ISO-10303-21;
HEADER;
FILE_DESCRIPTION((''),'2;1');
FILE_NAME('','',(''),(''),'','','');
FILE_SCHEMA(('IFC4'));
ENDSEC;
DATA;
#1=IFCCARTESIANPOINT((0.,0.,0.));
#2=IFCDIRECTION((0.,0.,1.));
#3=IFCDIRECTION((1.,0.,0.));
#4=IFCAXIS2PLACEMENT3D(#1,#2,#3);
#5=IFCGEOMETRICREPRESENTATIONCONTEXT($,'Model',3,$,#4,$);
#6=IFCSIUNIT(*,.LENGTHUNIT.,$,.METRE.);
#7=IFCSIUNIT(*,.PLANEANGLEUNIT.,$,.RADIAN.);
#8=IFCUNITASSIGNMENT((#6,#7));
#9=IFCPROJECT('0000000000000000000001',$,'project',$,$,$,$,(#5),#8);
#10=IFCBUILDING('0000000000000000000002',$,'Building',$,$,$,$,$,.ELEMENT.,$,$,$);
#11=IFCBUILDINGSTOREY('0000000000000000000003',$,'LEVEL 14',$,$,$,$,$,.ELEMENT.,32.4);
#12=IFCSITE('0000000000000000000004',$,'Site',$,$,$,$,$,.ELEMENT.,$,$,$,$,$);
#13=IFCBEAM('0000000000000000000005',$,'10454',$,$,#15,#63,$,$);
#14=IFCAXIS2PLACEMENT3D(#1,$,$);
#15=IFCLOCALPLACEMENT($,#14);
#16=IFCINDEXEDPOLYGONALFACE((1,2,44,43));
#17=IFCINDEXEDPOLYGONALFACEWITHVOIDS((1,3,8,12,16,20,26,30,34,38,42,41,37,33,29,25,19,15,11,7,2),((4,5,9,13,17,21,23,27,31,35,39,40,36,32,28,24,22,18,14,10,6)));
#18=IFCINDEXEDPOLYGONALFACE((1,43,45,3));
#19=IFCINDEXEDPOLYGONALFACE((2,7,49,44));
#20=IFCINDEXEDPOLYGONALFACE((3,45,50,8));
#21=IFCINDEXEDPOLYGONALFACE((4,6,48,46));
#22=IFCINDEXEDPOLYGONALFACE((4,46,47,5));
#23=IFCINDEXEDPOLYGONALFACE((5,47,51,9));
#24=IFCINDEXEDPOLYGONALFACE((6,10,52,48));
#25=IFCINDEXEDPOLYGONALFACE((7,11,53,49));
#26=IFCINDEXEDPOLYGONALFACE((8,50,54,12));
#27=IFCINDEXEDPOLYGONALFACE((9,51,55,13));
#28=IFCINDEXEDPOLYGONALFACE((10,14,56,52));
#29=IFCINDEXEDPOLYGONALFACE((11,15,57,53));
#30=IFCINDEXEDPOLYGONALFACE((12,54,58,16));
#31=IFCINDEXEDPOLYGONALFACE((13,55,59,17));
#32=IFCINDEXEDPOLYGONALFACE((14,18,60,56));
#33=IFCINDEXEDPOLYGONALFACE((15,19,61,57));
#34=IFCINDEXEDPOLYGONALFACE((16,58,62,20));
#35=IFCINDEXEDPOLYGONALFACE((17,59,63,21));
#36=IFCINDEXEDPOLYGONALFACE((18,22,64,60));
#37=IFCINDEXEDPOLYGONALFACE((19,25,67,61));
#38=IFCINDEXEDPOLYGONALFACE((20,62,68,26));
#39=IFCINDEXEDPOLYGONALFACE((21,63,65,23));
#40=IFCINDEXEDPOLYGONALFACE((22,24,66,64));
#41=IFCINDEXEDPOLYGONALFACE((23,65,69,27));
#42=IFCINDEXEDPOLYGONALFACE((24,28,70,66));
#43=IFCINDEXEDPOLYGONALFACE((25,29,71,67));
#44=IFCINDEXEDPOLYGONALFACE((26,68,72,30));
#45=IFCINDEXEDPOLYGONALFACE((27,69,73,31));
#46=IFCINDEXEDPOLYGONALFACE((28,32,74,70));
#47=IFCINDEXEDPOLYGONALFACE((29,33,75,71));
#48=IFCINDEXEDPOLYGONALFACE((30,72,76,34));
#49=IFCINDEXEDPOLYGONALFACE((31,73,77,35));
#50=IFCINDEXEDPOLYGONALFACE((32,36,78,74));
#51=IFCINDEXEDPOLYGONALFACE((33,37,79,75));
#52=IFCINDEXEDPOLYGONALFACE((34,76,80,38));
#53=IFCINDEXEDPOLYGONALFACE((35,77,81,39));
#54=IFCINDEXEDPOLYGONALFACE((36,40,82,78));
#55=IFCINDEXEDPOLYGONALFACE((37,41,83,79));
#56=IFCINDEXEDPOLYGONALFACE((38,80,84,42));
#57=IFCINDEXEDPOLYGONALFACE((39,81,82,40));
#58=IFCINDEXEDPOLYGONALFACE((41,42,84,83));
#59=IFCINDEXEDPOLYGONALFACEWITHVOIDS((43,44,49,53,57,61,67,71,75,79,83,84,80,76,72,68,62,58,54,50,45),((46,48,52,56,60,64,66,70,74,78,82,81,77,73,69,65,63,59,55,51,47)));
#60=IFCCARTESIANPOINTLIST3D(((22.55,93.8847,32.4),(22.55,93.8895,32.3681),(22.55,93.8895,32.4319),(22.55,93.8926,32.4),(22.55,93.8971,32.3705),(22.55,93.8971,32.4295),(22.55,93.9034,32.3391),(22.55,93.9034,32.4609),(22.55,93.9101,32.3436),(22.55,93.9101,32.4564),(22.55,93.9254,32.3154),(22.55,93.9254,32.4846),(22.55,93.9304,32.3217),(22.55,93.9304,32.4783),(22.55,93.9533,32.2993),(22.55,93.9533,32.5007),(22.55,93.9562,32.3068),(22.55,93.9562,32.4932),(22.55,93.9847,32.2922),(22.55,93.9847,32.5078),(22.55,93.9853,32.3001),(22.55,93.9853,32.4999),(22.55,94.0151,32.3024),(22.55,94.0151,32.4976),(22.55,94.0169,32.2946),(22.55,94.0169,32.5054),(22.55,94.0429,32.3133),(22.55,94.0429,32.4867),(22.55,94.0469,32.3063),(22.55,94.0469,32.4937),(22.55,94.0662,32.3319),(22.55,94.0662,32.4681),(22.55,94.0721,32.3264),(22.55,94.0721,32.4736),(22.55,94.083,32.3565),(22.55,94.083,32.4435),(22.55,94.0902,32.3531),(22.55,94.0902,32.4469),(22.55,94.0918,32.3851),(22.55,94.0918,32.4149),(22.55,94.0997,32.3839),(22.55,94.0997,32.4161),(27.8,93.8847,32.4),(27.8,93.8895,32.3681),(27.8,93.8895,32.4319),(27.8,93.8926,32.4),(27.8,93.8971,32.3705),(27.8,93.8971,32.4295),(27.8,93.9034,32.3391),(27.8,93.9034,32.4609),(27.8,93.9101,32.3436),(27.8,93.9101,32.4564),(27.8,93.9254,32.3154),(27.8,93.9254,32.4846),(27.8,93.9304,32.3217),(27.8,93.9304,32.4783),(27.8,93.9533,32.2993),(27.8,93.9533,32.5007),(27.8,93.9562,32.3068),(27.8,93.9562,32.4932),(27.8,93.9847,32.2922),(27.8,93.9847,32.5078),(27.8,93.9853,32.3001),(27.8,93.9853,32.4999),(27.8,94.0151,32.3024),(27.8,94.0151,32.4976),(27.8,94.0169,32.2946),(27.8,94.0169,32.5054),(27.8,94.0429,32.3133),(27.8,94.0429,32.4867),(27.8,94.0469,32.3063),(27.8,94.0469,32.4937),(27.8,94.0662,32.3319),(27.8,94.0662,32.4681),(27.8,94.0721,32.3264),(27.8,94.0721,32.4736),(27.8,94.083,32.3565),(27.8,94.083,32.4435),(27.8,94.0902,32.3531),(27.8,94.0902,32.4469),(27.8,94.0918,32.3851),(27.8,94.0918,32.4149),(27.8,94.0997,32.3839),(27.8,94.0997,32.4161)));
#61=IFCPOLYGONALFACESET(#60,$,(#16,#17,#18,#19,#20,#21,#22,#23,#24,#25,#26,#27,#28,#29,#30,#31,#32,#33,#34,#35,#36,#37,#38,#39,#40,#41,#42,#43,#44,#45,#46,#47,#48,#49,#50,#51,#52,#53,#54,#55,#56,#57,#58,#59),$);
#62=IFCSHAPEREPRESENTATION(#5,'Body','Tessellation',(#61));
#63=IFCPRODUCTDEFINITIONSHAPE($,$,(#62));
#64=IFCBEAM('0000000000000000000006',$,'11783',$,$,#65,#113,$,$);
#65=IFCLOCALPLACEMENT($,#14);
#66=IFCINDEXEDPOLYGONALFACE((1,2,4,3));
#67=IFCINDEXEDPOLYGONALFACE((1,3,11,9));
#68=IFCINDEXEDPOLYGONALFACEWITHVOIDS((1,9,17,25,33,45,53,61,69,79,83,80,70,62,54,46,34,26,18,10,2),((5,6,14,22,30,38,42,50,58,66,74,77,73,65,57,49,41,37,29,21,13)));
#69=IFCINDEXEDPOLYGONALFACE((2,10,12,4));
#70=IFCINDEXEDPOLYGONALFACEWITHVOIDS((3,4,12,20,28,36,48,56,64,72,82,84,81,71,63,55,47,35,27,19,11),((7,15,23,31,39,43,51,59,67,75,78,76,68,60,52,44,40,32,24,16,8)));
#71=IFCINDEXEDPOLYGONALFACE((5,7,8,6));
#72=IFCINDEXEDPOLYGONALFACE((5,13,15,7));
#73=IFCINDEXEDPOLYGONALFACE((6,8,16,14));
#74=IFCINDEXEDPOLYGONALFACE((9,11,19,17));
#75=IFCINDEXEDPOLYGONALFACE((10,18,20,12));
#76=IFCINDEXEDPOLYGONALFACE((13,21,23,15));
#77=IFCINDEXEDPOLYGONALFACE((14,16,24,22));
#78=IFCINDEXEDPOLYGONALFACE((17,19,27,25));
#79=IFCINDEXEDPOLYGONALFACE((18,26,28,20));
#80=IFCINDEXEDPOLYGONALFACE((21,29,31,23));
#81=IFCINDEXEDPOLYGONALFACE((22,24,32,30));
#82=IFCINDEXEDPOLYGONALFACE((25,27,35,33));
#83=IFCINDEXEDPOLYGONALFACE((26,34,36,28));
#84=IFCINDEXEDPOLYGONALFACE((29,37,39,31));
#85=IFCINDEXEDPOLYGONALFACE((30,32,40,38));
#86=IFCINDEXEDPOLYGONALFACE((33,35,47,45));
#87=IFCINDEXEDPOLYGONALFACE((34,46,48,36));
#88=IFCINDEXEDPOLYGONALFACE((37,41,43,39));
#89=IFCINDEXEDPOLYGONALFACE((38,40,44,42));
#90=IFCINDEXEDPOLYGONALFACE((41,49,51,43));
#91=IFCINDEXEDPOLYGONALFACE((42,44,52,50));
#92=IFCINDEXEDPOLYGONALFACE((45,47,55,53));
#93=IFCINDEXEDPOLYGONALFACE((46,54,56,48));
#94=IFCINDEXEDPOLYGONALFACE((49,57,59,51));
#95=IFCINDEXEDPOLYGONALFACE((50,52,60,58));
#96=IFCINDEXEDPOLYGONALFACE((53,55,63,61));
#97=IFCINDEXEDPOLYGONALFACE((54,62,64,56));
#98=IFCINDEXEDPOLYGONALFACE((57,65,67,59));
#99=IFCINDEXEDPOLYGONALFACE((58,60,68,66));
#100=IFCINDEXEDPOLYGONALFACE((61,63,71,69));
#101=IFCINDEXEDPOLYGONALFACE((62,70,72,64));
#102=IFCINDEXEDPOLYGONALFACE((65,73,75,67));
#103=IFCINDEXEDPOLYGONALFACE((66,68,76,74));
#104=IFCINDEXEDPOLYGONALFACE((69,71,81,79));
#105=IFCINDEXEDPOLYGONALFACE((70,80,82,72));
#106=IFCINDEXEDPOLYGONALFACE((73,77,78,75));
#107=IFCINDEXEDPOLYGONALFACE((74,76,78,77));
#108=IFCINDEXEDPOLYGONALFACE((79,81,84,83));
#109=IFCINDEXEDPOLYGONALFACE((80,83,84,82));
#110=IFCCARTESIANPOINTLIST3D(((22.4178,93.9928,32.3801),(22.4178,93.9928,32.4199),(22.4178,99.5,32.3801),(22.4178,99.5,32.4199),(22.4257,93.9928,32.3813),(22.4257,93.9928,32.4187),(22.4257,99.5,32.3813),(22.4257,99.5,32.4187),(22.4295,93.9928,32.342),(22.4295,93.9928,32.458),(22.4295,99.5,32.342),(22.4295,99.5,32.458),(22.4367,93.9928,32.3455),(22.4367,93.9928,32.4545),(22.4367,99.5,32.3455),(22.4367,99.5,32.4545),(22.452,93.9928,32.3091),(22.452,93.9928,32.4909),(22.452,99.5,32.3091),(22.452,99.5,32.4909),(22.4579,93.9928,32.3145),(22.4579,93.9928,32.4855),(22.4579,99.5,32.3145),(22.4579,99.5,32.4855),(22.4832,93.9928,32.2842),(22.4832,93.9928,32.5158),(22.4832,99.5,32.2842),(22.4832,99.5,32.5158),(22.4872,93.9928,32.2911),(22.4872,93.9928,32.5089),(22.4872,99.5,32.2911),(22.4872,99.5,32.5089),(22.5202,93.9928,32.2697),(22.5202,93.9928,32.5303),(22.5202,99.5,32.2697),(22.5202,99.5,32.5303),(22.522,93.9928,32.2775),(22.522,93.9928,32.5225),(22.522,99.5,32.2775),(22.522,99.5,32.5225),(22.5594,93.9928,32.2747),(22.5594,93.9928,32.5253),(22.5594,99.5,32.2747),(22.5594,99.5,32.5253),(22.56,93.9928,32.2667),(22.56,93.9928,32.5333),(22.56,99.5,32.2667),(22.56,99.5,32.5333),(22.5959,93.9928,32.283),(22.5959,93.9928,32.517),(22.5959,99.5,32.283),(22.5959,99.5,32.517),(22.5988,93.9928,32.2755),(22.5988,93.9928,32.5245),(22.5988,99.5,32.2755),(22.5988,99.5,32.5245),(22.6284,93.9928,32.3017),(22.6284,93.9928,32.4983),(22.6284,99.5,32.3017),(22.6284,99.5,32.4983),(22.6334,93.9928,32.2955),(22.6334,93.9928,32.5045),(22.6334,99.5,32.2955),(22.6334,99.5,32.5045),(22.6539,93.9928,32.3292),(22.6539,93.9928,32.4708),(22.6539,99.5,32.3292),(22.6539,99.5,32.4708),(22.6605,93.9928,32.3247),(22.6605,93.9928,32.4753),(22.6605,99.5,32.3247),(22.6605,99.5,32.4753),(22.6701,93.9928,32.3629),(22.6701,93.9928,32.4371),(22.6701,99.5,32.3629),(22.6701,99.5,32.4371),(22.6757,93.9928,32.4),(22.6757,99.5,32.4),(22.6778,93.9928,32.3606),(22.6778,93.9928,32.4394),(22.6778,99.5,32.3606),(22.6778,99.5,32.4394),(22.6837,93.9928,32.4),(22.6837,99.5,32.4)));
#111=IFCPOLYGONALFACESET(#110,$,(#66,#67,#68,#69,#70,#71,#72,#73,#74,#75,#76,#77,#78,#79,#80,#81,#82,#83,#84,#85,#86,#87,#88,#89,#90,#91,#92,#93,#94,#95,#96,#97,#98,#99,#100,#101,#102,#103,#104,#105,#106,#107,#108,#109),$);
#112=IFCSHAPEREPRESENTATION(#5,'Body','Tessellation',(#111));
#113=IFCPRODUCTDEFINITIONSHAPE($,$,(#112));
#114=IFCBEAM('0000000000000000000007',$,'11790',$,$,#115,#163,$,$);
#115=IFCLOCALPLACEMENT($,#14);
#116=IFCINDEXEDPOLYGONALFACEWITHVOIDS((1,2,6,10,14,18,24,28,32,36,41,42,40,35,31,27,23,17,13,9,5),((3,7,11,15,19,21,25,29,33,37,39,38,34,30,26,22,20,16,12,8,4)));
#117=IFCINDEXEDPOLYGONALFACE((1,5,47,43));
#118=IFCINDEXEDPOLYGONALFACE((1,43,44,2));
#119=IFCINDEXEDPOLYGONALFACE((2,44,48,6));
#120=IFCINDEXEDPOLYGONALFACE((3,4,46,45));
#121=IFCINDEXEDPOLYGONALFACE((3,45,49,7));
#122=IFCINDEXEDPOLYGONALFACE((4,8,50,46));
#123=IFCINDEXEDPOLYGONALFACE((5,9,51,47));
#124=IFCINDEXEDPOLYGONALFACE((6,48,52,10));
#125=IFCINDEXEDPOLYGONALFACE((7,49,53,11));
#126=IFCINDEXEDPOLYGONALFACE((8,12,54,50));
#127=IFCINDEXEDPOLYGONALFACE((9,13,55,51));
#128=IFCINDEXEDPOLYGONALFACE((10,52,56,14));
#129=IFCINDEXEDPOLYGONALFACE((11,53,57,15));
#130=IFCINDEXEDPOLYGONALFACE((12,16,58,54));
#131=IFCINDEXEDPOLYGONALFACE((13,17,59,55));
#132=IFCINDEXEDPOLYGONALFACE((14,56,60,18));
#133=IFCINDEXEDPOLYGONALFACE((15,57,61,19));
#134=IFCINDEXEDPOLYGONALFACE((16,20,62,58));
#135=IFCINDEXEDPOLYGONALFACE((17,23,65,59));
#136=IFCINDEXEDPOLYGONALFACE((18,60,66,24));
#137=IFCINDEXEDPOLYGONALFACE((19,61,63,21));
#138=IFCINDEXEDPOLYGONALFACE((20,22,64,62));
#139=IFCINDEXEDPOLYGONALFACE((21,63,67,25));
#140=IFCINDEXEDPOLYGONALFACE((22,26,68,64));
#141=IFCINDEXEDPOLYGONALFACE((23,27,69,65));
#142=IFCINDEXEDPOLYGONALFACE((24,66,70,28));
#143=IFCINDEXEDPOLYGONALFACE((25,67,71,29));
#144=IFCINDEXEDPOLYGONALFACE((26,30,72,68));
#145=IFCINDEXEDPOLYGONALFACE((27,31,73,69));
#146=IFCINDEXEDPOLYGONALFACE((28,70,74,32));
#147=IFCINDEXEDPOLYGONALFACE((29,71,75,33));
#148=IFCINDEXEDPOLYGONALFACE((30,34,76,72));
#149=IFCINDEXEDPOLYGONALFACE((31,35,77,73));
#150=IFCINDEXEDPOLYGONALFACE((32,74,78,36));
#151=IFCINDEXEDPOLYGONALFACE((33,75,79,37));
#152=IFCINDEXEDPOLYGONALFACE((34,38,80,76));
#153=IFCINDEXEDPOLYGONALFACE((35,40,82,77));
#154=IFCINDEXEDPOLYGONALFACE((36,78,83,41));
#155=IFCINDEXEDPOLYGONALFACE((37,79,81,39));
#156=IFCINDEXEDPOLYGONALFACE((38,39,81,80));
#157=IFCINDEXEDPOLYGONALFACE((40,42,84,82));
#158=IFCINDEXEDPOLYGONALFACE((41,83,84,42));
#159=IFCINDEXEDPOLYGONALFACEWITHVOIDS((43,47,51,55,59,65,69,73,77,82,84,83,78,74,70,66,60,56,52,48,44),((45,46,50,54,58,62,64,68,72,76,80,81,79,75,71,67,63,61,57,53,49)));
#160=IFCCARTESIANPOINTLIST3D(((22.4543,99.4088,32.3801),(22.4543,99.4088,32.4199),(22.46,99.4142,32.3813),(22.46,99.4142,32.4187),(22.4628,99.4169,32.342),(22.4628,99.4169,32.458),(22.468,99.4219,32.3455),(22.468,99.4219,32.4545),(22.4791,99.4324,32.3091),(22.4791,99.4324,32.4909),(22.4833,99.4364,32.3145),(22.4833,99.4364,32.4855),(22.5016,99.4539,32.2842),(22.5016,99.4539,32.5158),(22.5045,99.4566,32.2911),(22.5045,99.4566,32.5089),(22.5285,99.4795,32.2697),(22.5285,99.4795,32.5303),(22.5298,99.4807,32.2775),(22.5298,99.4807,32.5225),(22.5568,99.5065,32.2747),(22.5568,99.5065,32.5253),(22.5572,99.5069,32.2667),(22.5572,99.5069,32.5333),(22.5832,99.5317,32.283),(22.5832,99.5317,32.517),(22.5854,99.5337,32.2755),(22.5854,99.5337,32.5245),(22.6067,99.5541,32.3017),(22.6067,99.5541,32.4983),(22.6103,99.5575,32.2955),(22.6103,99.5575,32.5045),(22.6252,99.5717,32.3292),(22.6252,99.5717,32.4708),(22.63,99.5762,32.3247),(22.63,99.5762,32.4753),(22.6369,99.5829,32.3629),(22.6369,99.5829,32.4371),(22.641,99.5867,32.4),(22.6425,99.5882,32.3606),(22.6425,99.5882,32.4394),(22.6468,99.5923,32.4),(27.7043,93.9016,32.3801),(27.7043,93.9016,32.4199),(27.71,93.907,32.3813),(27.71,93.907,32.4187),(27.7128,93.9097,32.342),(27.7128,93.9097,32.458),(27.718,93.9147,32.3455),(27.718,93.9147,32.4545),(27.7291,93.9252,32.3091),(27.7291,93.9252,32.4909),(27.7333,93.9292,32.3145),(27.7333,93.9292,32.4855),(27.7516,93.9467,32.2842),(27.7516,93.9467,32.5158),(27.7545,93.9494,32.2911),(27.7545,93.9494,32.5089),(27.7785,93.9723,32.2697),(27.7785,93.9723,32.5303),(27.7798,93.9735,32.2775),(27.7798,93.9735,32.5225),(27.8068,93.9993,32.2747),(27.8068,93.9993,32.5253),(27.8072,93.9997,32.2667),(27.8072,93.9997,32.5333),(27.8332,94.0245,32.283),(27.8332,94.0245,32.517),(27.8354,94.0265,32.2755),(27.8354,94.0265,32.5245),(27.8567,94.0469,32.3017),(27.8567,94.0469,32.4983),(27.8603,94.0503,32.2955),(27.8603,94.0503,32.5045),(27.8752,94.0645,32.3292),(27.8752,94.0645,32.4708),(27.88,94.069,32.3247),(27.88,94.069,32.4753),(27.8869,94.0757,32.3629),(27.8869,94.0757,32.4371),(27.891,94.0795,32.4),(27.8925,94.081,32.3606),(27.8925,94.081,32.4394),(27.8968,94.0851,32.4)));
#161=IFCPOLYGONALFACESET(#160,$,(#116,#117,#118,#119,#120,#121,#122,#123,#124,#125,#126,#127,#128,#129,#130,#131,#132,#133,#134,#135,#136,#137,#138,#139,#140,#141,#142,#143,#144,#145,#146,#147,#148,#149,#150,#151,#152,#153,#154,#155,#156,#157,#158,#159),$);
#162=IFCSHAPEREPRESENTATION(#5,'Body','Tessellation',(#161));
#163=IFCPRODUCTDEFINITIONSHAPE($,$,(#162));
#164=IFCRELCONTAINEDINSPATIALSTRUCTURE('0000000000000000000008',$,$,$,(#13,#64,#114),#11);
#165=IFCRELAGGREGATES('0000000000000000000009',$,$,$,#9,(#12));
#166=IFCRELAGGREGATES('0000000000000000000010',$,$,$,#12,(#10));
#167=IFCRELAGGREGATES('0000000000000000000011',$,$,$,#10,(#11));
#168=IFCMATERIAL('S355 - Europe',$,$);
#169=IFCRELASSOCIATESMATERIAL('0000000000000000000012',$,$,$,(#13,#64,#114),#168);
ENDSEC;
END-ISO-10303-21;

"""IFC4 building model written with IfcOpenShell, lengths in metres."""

from ifc_helpers import new_model, si_unit, frame, origin_with_axes, origin_2d_with_axis, place, context, project, spatial, hollow_circle, extrude, material, material_profile, profile_set, profile_usage, element, save


model = new_model("IFC4")

# Units and contexts
model_context = context("Model", 3, world=origin_with_axes())
ifc_project = project(units=[si_unit("LENGTHUNIT", "METRE"), si_unit("PLANEANGLEUNIT", "RADIAN")], contexts=[model_context])

# Site, building, storey
site = spatial("IfcSite", under=ifc_project, Name="Site", CompositionType="ELEMENT")
building = spatial("IfcBuilding", under=site, Name="Building", CompositionType="ELEMENT")
storey = spatial("IfcBuildingStorey", under=building, Name="LEVEL 14", CompositionType="ELEMENT", Elevation=32.4)

# Shared definitions
ifc_material = material(Name="S355 - Europe")

# Beams
ifc_material_profile_1 = material_profile(ifc_material, hollow_circle(Radius=0.1081, WallThickness=0.008, at=origin_2d_with_axis()))
ifc_profile_set_1 = profile_set([ifc_material_profile_1])
ifc_profile_usage_1 = profile_usage(ifc_profile_set_1, cardinal=10)
beam_1_placement = place(None, frame((27.8, 93.9928, 32.4), z_axis=(-1.0, 0.0, 0.0), x_axis=(0.0, -1.0, 0.0)))
element("IfcBeam", 1, at=beam_1_placement, inside=storey, material=ifc_profile_usage_1, Name="10454", context=model_context, shape_type="SweptSolid", body=[
    extrude(hollow_circle(Radius=0.1081, WallThickness=0.008, at=origin_2d_with_axis()), origin_with_axes(), (0.0, 0.0, 1.0), 5.25),
])
ifc_material_profile_2 = material_profile(ifc_material, hollow_circle(Radius=0.1337, WallThickness=0.008, at=origin_2d_with_axis()))
ifc_profile_set_2 = profile_set([ifc_material_profile_2])
ifc_profile_usage_2 = profile_usage(ifc_profile_set_2, cardinal=10)
beam_2_placement = place(None, frame((22.55, 99.5, 32.4), z_axis=(0.0, -1.0, 0.0), x_axis=(1.0, 0.0, 0.0)))
element("IfcBeam", 2, at=beam_2_placement, inside=storey, material=ifc_profile_usage_2, Name="11783", context=model_context, shape_type="SweptSolid", body=[
    extrude(hollow_circle(Radius=0.1337, WallThickness=0.008, at=origin_2d_with_axis()), origin_with_axes(), (0.0, 0.0, 1.0), 5.5072),
])
ifc_material_profile_3 = material_profile(ifc_material, hollow_circle(Radius=0.1337, WallThickness=0.008, at=origin_2d_with_axis()))
ifc_profile_set_3 = profile_set([ifc_material_profile_3])
ifc_profile_usage_3 = profile_usage(ifc_profile_set_3, cardinal=10)
beam_3_placement = place(None, frame((22.55, 99.5, 32.4), z_axis=(0.690003, -0.723807, 0.0), x_axis=(0.723807, 0.690003, 0.0)))
element("IfcBeam", 3, at=beam_3_placement, inside=storey, material=ifc_profile_usage_3, Name="11790", context=model_context, shape_type="SweptSolid", body=[
    extrude(hollow_circle(Radius=0.1337, WallThickness=0.008, at=origin_2d_with_axis()), origin_with_axes(), (0.0, 0.0, 1.0), 7.6087),
])

save(model, "model.ifc")
